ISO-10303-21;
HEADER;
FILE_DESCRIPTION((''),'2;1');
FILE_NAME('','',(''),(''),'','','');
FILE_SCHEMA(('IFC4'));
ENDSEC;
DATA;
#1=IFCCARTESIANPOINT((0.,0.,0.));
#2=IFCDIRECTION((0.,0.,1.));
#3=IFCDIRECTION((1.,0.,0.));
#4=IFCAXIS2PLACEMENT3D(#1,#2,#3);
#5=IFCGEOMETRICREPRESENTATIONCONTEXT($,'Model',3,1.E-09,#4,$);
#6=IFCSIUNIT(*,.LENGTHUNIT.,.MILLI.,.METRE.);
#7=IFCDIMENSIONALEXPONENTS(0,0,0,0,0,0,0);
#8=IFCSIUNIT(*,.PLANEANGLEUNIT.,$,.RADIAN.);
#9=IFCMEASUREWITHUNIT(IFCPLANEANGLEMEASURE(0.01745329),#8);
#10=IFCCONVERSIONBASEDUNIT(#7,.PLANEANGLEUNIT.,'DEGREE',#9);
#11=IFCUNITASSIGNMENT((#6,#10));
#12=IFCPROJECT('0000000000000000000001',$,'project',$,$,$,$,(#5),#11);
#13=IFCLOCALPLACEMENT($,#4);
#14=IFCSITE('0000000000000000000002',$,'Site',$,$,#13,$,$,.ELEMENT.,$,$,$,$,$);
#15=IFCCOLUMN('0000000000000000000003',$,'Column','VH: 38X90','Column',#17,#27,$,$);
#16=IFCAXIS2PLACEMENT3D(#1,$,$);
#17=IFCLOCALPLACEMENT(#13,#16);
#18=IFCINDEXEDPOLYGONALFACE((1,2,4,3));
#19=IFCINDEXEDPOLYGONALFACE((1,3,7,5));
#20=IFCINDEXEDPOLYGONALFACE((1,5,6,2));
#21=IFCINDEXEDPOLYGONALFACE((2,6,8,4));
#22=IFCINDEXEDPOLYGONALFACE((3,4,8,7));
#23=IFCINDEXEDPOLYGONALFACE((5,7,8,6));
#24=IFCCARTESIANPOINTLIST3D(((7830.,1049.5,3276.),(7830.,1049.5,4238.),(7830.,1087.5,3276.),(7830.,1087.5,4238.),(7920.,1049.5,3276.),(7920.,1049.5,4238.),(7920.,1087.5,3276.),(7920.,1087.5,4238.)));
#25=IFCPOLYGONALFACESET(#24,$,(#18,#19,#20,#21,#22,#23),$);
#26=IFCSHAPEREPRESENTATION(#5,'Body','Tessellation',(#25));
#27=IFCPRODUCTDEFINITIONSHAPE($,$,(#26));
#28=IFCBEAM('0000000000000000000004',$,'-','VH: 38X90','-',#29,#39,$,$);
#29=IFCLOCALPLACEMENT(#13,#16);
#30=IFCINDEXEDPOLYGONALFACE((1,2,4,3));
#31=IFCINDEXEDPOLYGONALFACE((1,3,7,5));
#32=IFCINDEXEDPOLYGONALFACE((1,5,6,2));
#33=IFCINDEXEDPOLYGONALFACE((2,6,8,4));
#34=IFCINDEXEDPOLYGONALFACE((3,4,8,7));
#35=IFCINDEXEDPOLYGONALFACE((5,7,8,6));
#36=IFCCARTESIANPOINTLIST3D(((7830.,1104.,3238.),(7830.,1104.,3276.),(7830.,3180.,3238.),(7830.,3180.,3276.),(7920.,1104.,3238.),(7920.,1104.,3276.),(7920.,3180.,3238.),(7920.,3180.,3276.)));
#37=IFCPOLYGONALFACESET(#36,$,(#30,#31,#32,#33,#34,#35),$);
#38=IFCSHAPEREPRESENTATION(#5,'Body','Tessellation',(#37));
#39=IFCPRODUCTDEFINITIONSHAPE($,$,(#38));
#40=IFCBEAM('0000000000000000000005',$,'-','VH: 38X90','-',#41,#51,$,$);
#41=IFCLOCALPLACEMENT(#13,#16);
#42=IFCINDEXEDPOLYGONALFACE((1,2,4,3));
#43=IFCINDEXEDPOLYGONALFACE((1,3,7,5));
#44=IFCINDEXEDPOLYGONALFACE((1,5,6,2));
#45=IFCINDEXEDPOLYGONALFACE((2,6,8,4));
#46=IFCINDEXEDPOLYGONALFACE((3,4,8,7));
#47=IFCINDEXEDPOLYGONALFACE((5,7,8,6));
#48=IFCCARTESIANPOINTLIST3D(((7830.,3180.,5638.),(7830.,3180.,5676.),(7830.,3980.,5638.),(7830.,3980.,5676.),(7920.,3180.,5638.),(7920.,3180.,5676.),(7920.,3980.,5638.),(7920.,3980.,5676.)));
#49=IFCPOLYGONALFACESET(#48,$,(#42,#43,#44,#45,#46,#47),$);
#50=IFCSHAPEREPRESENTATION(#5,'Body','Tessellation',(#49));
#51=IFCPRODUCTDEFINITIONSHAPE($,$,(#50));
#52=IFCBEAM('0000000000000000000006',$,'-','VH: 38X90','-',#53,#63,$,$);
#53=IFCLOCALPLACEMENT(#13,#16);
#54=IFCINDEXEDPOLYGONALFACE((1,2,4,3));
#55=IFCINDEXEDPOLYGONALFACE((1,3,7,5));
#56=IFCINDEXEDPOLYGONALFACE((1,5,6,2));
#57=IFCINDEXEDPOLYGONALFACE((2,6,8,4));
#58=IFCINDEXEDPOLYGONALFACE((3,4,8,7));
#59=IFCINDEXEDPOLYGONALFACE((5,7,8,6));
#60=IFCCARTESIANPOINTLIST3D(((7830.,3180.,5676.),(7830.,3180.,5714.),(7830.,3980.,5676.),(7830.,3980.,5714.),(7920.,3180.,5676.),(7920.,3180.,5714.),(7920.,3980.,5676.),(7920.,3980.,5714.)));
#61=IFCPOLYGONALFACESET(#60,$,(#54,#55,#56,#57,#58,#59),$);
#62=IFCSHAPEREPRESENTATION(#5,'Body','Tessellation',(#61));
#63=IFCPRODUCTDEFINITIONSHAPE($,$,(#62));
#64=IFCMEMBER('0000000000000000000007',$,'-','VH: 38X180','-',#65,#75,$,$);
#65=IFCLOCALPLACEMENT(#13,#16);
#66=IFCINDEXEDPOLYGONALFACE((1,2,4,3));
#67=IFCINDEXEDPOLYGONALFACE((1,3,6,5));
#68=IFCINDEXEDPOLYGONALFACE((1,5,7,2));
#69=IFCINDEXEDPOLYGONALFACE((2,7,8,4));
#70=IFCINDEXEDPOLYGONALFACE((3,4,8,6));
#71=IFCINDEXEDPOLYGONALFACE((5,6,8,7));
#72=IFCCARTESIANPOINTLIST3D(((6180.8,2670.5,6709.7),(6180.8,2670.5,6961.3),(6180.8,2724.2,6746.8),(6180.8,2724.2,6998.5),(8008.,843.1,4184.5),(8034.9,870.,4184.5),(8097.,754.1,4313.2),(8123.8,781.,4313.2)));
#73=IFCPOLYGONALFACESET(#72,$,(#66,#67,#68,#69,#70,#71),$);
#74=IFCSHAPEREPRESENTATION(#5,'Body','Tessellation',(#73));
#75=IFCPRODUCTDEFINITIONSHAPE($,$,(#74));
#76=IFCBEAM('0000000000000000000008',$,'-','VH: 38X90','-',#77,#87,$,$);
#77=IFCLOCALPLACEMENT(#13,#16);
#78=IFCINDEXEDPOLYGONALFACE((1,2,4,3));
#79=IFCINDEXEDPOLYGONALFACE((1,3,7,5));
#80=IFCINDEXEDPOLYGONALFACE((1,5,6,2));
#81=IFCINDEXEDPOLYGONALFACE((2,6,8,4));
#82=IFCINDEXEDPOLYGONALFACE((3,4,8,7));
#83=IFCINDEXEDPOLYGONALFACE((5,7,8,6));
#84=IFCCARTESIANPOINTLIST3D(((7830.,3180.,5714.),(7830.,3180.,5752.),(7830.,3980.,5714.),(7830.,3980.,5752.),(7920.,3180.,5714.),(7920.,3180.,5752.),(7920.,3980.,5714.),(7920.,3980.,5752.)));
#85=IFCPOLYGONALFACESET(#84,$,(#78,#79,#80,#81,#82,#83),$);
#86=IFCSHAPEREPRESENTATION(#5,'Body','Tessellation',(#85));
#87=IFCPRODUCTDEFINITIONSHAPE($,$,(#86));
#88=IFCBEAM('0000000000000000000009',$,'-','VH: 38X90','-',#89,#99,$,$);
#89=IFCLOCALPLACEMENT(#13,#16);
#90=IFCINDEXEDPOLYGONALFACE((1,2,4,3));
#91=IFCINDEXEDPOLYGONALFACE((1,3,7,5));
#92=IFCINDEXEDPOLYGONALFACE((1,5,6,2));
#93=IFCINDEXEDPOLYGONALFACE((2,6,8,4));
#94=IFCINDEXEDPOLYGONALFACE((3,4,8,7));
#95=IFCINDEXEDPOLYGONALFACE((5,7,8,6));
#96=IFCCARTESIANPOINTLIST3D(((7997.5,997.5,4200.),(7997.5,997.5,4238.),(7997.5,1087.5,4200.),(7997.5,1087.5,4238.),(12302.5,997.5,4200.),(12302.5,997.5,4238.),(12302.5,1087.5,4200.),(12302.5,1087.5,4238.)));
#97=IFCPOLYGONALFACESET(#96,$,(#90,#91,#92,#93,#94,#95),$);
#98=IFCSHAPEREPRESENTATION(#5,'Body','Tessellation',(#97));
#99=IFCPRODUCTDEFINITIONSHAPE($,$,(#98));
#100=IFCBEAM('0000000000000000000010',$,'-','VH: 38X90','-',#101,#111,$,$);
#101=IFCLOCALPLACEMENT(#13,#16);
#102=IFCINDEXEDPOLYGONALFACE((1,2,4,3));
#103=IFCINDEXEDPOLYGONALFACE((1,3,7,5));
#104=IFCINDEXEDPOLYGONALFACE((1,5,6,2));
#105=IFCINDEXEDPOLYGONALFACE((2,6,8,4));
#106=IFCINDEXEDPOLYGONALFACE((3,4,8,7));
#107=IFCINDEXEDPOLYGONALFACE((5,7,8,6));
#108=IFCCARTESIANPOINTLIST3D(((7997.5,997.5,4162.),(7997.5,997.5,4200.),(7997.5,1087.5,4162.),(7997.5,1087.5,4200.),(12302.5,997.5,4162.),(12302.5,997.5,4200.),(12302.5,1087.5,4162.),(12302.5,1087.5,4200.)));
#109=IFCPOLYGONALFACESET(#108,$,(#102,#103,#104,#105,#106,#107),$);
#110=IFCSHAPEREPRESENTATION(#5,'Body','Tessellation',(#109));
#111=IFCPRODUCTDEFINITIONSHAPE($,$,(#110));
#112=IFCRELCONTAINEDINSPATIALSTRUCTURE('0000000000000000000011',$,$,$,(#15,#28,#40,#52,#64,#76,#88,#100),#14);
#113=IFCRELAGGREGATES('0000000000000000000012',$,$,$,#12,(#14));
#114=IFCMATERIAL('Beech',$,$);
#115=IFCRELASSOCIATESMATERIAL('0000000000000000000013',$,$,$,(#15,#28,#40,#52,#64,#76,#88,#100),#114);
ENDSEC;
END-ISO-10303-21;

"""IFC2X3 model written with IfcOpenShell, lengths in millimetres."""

from ifc_helpers import new_model, entity, si_unit, converted_unit, frame, origin, origin_with_axes, origin_2d, place, context, project, spatial, rectangle, extrude, clip, halfspace, material, element, save


model = new_model("IFC2X3")

# Units and contexts
model_context = context("Model", 3, precision=1e-09, world=origin_with_axes())
ifc_project = project(units=[si_unit("LENGTHUNIT", "METRE", prefix="MILLI"), converted_unit("PLANEANGLEUNIT", "DEGREE", entity("IfcPlaneAngleMeasure", 0.01745329), si_unit("PLANEANGLEUNIT", "RADIAN"), dimensions=[0, 0, 0, 0, 0, 0, 0])], contexts=[model_context])

# Site
site_placement = place(None, origin_with_axes())
site = spatial("IfcSite", under=ifc_project, at=site_placement, Name="Site", CompositionType="ELEMENT")

# Column
ifc_material = material(Name="Beech")
column_1_placement = place(None, frame((7875.0, 1068.5, 3276.0), z_axis=(0.0, 0.0, -1.0), x_axis=(0.0, -1.0, 0.0)))
element("IfcColumn", 1, at=column_1_placement, inside=site, material=ifc_material, Name="Column", Description="VH: 38X90", ObjectType="Column", context=model_context, shape_type="SweptSolid", body=[
    extrude(rectangle(XDim=38.0, YDim=90.0, at=origin_2d()), origin(), (0.0, 0.0, -1.0), 962.0),
])

# Beams
beam_1_placement = place(None, frame((7875.0, 3180.0, 3257.0), z_axis=(0.0, 1.0, 0.0), x_axis=(0.0, 0.0, -1.0)))
element("IfcBeam", 2, at=beam_1_placement, inside=site, material=ifc_material, Name="-", Description="VH: 38X90", ObjectType="-", context=model_context, shape_type="SweptSolid", body=[
    extrude(rectangle(XDim=38.0, YDim=90.0, at=origin_2d()), origin(), (0.0, 0.0, -1.0), 2076.0),
])
for number, where, z_axis, x_axis, name in (
    (3, (7875.0, 3180.0, 5657.0), (0.0, -1.0, 0.0), (0.0, 0.0, -1.0), "-"),
    (4, (7875.0, 3180.0, 5695.0), (0.0, -1.0, 0.0), (0.0, 0.0, -1.0), "-"),
):
    element("IfcBeam", number, at=place(None, frame(where, z_axis=z_axis, x_axis=x_axis)), inside=site, material=ifc_material, Name=name, Description="VH: 38X90", ObjectType="-", context=model_context, shape_type="SweptSolid", body=[
        extrude(rectangle(XDim=38.0, YDim=90.0, at=origin_2d()), origin(), (0.0, 0.0, -1.0), 800.0),
    ])

# Member
member_1_placement = place(None, frame((8065.9, 812.1, 4248.9), z_axis=(0.505723, -0.505767, -0.698888), x_axis=(0.707137, 0.707076, 0.0)))
element("IfcMember", 5, at=member_1_placement, inside=site, material=ifc_material, Name="-", Description="VH: 38X180", ObjectType="-", context=model_context, shape_type="Clipping", body=[
    clip(extrude(rectangle(XDim=38.0, YDim=180.0, at=origin_2d()), origin(), (0.0, 0.0, -1.0), 4351.8), halfspace(frame((-1907.2, -3569.2, 2426.8), z_axis=(0.707137, 0.494167, 0.505723), x_axis=(0.707076, -0.494209, -0.505767)), True)),
])

# Beams
beam_2_placement = place(None, frame((7875.0, 3180.0, 5733.0), z_axis=(0.0, -1.0, 0.0), x_axis=(0.0, 0.0, -1.0)))
element("IfcBeam", 6, at=beam_2_placement, inside=site, material=ifc_material, Name="-", Description="VH: 38X90", ObjectType="-", context=model_context, shape_type="SweptSolid", body=[
    extrude(rectangle(XDim=38.0, YDim=90.0, at=origin_2d()), origin(), (0.0, 0.0, -1.0), 800.0),
])
for number, where, z_axis, x_axis, name in (
    (7, (7997.5, 1042.5, 4219.0), (-1.0, 0.0, 0.0), (0.0, 0.0, 1.0), "-"),
    (8, (7997.5, 1042.5, 4181.0), (-1.0, 0.0, 0.0), (0.0, 0.0, 1.0), "-"),
):
    element("IfcBeam", number, at=place(None, frame(where, z_axis=z_axis, x_axis=x_axis)), inside=site, material=ifc_material, Name=name, Description="VH: 38X90", ObjectType="-", context=model_context, shape_type="SweptSolid", body=[
        extrude(rectangle(XDim=38.0, YDim=90.0, at=origin_2d()), origin(), (0.0, 0.0, -1.0), 4305.0),
    ])

save(model, "model.ifc")
